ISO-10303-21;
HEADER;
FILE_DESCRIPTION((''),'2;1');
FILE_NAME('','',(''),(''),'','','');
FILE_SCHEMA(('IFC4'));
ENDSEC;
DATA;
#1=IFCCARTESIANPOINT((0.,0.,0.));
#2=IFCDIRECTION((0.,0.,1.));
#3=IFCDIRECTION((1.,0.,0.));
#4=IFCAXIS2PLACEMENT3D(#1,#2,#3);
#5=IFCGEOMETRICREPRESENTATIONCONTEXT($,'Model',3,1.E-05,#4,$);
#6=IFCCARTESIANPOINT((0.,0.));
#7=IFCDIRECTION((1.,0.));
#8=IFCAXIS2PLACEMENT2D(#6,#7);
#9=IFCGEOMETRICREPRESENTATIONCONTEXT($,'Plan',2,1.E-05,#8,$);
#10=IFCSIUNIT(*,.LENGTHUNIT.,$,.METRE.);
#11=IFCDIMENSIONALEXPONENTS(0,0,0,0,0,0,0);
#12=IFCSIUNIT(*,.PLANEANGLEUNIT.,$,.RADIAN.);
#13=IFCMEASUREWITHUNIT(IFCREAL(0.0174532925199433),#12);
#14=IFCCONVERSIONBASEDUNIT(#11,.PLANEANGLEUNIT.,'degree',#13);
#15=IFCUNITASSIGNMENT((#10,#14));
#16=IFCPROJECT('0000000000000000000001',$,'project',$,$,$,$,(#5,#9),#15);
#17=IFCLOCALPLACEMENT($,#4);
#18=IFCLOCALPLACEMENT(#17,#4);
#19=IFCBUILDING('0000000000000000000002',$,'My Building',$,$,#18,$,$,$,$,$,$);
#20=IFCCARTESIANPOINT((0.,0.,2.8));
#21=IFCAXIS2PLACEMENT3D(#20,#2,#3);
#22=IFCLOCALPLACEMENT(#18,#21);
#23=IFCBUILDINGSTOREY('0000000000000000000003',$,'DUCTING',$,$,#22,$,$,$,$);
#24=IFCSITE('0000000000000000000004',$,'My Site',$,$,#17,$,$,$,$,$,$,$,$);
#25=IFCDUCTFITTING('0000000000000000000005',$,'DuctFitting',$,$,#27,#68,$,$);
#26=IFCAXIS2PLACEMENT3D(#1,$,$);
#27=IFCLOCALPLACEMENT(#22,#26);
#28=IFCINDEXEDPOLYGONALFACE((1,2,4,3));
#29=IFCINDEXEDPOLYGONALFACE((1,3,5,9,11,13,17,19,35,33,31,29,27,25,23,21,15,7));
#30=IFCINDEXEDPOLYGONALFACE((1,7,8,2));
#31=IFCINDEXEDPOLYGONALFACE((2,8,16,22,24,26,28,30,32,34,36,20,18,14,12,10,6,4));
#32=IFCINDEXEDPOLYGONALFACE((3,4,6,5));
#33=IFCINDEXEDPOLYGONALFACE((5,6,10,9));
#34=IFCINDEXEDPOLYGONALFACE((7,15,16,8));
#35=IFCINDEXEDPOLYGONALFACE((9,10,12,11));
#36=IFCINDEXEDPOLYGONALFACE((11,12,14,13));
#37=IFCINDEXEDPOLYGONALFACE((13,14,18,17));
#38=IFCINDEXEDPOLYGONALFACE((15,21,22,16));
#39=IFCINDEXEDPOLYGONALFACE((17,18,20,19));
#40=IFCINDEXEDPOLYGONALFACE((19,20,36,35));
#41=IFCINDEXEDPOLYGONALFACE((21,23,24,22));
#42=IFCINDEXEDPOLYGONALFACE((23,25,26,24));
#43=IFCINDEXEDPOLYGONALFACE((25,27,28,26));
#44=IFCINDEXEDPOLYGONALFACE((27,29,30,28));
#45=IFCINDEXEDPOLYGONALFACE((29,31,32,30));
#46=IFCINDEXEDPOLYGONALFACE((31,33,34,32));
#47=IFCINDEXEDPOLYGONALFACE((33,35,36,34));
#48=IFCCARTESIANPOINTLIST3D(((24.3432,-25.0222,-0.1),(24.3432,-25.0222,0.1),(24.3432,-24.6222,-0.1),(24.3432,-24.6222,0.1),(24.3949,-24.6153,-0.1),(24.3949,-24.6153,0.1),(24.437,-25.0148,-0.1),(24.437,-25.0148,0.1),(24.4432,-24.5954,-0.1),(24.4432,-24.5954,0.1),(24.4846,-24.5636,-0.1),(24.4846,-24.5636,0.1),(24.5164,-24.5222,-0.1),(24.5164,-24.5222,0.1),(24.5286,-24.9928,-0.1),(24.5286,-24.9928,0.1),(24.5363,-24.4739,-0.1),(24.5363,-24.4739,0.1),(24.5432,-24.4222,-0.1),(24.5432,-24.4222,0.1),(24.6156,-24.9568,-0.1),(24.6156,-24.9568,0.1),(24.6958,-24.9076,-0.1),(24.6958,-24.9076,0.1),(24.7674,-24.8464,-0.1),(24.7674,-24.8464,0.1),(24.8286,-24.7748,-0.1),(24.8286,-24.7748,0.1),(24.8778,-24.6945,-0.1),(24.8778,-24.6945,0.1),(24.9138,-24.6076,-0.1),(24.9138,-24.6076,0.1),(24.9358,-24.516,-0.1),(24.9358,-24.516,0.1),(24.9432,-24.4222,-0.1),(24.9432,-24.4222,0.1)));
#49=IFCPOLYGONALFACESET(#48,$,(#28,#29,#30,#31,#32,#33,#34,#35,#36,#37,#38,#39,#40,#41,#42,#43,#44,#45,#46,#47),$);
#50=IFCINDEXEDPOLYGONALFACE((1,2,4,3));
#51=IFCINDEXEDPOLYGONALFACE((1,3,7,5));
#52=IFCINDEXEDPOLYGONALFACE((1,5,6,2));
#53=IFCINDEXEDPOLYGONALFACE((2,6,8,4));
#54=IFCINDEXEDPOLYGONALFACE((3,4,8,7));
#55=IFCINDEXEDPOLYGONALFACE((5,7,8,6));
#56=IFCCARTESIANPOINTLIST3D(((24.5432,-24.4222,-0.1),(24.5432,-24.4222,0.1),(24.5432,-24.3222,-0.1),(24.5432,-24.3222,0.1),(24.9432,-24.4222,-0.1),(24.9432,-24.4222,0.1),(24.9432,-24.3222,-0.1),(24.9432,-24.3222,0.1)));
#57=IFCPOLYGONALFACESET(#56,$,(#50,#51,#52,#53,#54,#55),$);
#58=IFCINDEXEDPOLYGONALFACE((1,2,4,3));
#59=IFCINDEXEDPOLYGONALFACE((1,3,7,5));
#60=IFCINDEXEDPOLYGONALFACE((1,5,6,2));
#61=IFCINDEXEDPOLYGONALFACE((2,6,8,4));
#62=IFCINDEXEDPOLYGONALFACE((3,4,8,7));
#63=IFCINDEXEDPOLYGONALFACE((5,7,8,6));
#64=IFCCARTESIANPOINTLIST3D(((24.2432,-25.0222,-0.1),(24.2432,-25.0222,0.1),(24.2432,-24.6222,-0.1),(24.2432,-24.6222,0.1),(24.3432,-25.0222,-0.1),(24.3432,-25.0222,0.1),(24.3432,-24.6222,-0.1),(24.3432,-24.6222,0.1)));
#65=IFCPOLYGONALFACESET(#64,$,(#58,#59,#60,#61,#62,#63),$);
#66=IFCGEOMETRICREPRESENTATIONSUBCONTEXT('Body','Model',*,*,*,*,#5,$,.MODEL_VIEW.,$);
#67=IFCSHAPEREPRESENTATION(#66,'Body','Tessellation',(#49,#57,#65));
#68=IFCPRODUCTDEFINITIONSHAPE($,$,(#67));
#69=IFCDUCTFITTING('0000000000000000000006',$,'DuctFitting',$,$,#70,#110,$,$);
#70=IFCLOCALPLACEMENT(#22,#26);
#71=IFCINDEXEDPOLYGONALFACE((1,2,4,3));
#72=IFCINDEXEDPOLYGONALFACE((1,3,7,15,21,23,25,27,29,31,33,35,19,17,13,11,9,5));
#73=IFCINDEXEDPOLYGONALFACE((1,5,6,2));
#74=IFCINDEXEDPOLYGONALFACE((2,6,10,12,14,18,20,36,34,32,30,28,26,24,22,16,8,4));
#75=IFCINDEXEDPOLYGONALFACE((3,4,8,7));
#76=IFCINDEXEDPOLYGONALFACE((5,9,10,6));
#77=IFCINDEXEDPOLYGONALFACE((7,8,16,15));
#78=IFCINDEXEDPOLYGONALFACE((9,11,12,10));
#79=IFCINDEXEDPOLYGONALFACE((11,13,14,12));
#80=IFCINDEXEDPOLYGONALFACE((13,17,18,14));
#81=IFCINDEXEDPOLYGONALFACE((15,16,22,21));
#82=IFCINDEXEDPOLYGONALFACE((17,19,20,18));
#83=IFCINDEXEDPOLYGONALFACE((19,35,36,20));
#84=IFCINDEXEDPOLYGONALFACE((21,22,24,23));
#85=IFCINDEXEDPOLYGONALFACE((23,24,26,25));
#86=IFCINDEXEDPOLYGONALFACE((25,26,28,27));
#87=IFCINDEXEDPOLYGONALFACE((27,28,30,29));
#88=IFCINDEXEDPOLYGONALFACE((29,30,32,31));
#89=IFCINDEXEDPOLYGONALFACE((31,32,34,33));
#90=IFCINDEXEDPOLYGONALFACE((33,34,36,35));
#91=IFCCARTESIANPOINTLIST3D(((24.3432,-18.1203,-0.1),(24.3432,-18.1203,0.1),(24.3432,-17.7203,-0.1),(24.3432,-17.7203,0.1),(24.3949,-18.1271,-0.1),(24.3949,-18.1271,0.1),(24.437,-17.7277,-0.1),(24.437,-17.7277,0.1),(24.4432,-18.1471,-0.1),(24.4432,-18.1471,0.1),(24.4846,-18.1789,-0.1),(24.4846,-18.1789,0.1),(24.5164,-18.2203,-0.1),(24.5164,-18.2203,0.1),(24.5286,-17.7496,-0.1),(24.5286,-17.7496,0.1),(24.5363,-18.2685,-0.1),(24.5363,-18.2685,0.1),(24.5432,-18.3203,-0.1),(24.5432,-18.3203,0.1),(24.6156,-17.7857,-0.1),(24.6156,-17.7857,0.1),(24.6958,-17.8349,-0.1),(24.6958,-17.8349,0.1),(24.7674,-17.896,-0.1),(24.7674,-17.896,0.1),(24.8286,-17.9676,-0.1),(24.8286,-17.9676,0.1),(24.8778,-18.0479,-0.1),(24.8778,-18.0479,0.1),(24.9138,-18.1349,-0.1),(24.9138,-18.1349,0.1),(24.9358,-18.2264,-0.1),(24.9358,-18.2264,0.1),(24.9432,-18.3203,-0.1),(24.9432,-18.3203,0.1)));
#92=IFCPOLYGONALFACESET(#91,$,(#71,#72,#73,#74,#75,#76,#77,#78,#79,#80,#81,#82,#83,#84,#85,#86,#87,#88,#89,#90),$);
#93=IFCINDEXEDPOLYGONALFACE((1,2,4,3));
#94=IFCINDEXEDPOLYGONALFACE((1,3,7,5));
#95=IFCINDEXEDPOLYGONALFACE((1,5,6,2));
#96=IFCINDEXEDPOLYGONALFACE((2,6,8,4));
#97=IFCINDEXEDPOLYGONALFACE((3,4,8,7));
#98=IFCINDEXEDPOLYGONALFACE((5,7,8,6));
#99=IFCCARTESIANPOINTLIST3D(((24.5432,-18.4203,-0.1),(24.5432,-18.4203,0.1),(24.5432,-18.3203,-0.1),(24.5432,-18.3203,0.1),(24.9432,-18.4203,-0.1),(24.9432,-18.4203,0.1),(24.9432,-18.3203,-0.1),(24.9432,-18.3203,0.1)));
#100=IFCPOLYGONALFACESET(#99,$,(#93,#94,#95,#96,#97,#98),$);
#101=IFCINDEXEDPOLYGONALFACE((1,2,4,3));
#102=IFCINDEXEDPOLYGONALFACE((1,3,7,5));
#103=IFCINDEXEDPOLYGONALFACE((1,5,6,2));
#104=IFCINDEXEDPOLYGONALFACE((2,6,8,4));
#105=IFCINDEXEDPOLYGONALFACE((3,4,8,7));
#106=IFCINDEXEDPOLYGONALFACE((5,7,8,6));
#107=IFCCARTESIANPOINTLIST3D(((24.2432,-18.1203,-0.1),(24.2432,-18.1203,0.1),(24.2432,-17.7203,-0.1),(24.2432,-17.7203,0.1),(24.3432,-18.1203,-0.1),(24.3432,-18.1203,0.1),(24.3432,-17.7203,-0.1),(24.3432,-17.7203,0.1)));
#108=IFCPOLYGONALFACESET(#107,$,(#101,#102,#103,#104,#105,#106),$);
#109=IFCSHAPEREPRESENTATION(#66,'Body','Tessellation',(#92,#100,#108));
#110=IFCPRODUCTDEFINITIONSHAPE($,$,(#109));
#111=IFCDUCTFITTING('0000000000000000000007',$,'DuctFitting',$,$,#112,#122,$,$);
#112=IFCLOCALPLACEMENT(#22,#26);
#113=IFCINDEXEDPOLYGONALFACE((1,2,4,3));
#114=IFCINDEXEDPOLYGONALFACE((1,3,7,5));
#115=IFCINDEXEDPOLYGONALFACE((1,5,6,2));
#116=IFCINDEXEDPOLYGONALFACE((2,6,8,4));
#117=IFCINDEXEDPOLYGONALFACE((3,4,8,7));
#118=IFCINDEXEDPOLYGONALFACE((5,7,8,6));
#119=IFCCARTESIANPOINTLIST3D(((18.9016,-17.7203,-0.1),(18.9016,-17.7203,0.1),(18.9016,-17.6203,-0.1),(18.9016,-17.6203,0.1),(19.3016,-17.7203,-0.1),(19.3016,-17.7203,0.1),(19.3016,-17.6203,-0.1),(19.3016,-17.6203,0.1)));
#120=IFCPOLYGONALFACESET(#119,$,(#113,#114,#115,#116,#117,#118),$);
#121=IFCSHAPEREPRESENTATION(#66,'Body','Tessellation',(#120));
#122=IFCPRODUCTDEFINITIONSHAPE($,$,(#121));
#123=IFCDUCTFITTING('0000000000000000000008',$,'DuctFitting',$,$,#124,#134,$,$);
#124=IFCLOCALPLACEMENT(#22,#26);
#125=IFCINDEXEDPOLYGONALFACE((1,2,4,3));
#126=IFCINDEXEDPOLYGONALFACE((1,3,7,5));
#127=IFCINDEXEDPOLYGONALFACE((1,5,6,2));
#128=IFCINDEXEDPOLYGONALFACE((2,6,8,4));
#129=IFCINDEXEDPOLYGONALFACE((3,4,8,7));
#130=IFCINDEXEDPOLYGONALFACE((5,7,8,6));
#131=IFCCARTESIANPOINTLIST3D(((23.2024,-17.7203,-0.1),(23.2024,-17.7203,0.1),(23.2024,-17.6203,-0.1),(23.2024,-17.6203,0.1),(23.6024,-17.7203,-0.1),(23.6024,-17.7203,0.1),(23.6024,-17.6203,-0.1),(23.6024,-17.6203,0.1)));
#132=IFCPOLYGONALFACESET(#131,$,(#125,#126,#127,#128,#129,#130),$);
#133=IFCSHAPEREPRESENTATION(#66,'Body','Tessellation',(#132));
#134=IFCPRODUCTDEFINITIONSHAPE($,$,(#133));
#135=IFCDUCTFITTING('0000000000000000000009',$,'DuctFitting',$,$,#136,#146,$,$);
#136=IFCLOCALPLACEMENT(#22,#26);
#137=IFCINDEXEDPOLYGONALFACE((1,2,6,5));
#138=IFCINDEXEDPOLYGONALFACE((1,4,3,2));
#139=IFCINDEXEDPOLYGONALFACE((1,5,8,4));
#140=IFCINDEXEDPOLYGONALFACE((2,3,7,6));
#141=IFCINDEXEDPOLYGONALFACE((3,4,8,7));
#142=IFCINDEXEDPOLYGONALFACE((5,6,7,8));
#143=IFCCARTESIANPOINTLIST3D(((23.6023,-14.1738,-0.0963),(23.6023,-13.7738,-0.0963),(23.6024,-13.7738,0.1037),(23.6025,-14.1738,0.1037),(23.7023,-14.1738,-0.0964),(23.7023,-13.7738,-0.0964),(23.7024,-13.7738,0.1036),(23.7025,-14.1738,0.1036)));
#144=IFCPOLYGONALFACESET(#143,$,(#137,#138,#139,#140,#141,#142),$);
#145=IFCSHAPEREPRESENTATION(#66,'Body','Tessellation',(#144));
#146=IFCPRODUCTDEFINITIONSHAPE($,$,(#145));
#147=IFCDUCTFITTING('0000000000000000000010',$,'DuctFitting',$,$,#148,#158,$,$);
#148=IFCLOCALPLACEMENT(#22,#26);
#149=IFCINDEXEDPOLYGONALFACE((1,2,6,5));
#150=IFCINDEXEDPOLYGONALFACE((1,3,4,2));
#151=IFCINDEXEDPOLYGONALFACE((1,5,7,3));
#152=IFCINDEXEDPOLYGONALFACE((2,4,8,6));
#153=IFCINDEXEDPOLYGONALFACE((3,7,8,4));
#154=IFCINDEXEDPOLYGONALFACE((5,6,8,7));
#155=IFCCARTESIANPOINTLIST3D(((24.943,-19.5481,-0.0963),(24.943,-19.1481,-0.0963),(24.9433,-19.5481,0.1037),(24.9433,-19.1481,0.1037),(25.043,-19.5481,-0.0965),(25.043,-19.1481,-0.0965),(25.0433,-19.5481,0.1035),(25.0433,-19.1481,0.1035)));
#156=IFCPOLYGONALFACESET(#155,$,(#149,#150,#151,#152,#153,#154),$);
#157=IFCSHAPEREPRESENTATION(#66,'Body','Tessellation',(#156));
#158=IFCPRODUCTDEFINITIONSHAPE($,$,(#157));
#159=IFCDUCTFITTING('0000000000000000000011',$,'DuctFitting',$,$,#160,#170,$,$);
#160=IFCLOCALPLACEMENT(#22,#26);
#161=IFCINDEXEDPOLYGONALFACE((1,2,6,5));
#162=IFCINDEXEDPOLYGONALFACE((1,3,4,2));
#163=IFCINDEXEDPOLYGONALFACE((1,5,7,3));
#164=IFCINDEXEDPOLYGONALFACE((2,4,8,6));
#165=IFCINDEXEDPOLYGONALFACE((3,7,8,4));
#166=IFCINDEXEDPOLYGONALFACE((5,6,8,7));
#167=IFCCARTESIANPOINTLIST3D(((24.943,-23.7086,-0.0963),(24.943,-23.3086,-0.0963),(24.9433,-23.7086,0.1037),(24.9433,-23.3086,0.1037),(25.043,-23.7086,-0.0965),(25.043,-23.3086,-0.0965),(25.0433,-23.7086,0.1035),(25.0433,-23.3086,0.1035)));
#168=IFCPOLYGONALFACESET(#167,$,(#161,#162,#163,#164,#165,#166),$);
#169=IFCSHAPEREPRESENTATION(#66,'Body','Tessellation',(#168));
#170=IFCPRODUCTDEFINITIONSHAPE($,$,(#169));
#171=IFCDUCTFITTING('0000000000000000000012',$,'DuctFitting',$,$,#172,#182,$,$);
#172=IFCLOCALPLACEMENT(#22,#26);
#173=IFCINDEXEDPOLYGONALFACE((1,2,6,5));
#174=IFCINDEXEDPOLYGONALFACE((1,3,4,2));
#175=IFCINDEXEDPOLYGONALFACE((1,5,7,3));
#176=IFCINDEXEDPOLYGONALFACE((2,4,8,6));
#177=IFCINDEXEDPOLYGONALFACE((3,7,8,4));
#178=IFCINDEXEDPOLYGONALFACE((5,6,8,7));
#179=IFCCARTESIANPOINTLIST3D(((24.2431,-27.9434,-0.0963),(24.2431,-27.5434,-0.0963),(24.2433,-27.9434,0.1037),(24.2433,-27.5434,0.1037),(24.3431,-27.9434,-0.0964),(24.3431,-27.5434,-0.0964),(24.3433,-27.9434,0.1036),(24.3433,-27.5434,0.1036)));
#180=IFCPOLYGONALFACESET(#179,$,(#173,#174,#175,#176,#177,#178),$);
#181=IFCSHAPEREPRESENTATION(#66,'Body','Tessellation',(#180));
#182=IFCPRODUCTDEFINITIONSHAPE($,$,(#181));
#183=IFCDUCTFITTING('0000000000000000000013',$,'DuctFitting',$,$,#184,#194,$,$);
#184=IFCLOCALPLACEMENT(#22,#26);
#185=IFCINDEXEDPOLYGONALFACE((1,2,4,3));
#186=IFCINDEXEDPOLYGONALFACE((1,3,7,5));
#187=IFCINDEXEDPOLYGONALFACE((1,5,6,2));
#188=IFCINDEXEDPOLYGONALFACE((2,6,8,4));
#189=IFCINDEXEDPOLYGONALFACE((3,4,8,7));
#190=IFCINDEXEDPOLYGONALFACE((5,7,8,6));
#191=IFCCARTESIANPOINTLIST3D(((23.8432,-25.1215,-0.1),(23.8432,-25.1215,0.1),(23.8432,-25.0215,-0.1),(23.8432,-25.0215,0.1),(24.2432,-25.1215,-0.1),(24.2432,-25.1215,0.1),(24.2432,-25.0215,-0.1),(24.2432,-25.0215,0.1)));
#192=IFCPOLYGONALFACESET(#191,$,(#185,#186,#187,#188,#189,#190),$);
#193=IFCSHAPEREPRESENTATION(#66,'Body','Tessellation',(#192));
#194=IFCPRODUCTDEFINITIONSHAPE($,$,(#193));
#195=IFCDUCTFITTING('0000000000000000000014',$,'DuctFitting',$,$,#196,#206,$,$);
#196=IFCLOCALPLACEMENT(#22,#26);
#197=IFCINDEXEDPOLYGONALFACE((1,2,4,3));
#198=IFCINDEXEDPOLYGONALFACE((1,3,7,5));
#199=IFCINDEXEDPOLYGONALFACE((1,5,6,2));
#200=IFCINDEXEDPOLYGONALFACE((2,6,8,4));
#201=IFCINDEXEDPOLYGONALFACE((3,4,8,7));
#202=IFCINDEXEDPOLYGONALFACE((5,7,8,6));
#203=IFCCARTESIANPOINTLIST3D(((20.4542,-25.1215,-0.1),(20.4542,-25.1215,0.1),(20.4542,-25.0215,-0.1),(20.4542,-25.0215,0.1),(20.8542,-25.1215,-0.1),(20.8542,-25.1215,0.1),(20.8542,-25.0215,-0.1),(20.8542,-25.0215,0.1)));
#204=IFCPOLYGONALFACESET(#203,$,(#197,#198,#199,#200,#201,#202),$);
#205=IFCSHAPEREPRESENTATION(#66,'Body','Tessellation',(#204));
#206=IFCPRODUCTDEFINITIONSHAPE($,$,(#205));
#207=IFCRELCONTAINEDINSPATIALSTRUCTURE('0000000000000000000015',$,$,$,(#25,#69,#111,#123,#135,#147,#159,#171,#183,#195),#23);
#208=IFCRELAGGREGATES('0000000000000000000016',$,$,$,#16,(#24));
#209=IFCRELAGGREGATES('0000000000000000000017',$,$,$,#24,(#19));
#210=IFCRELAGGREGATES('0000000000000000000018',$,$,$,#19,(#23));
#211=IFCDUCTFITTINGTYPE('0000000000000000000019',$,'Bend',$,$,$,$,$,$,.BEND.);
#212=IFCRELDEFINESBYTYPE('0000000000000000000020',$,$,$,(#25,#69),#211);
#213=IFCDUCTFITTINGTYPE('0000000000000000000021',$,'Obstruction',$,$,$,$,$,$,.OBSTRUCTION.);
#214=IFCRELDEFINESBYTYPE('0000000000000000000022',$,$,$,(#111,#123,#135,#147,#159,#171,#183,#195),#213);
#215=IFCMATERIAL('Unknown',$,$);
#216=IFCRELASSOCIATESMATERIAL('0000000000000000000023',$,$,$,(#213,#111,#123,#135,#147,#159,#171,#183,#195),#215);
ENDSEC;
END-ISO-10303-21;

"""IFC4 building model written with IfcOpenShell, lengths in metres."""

from ifc_helpers import new_model, entity, si_unit, converted_unit, frame, origin_with_axes, origin_2d_with_axis, place, context, subcontext, project, spatial, line, arc, indexed_curve, rectangle, outline, extrude, source, transform, mapped, material, material_profile, profile_set, profile_usage, type_object, type_shapes, element, save


model = new_model("IFC4")

# Units and contexts
model_context = context("Model", 3, precision=1e-05, world=origin_with_axes())
plan_context = context("Plan", 2, precision=1e-05, world=origin_2d_with_axis())
body_context = subcontext(model_context, "Body", "Model", "MODEL_VIEW")
ifc_project = project(units=[si_unit("LENGTHUNIT", "METRE"), converted_unit("PLANEANGLEUNIT", "degree", entity("IfcReal", 0.0174532925199433), si_unit("PLANEANGLEUNIT", "RADIAN"), dimensions=[0, 0, 0, 0, 0, 0, 0])], contexts=[model_context, plan_context])

# Site, building, storey
site_placement = place(None, origin_with_axes())
site = spatial("IfcSite", under=ifc_project, at=site_placement, Name="My Site")
building_placement = place(site_placement, origin_with_axes())
building = spatial("IfcBuilding", under=site, at=building_placement, Name="My Building")
storey_placement = place(building_placement, frame((0.0, 0.0, 2.8), z_axis=(0.0, 0.0, 1.0), x_axis=(1.0, 0.0, 0.0)))
storey = spatial("IfcBuildingStorey", under=building, at=storey_placement, Name="DUCTING")

# Shared definitions
ifc_material = material(Name="Unknown")

# Duct fittings
duct_fitting_type_1 = type_object("IfcDuctFittingType", Name="Bend", PredefinedType="BEND")
shared_shape = source(origin_with_axes(), body_context, "Body", "SweptSolid", [
    extrude(outline(indexed_curve([(-0.2, 0.0), (-0.2586, 0.1414), (-0.4, 0.2), (-0.4, 0.6), (0.0243, 0.4243), (0.2, 0.0)], segments=[arc(1, 2, 3), line(3, 4), arc(4, 5, 6), line(6, 1)])), frame((0.0, -0.1, 0.1), z_axis=(0.0, -1.0, 0.0), x_axis=(1.0, 0.0, 0.0)), (0.0, 0.0, -1.0), 0.2),
    extrude(rectangle(XDim=0.4, YDim=0.2), origin_with_axes(), (0.0, 0.0, 1.0), 0.1),
    extrude(rectangle(XDim=0.4, YDim=0.2), frame((-0.4, 0.0, 0.5), z_axis=(-1.0, 0.0, 0.0), x_axis=(0.0, 0.0, -1.0)), (0.0, 0.0, 1.0), 0.1),
])
type_shapes(duct_fitting_type_1, [shared_shape])
for number, where, z_axis, x_axis, name in (
    (1, (24.7432, -24.3222, 0.0), (0.0, -1.0, 0.0), (1.0, 0.0, 0.0), "DuctFitting"),
    (2, (24.7432, -18.4203, 0.0), (0.0, 1.0, 0.0), (1.0, 0.0, 0.0), "DuctFitting"),
):
    element("IfcDuctFitting", number, at=place(storey_placement, frame(where, z_axis=z_axis, x_axis=x_axis)), inside=storey, type_object=duct_fitting_type_1, Name=name, context=body_context, shape_type="MappedRepresentation", body=[
        mapped(shared_shape, transform((0.0, 0.0, 0.0), x_axis=(1.0, 0.0, 0.0), y_axis=(0.0, 1.0, 0.0), z_axis=(0.0, 0.0, 1.0), scale=1.0)),
    ])
ifc_material_profile_1 = material_profile(ifc_material, rectangle(XDim=0.4, YDim=0.2))
ifc_profile_set_1 = profile_set([ifc_material_profile_1])
ifc_profile_usage_1 = profile_usage(ifc_profile_set_1, cardinal=5)
duct_fitting_type_2 = type_object("IfcDuctFittingType", Name="Obstruction", PredefinedType="OBSTRUCTION", material=ifc_profile_set_1)
duct_fitting_1_placement = place(storey_placement, frame((19.1016, -17.6203, 0.0), z_axis=(0.0, -1.0, 0.0), x_axis=(1.0, 0.0, 0.0)))
element("IfcDuctFitting", 3, at=duct_fitting_1_placement, inside=storey, type_object=duct_fitting_type_2, material=ifc_profile_usage_1, Name="DuctFitting", context=body_context, shape_type="SweptSolid", body=[
    extrude(rectangle(XDim=0.4, YDim=0.2), origin_with_axes(), (0.0, 0.0, 1.0), 0.1),
])
ifc_profile_usage_2 = profile_usage(ifc_profile_set_1, cardinal=5)
duct_fitting_2_placement = place(storey_placement, frame((23.4024, -17.6203, 0.0), z_axis=(0.0, -1.0, 0.0), x_axis=(1.0, 0.0, 0.0)))
element("IfcDuctFitting", 4, at=duct_fitting_2_placement, inside=storey, type_object=duct_fitting_type_2, material=ifc_profile_usage_2, Name="DuctFitting", context=body_context, shape_type="SweptSolid", body=[
    extrude(rectangle(XDim=0.4, YDim=0.2), origin_with_axes(), (0.0, 0.0, 1.0), 0.1),
])
ifc_profile_usage_3 = profile_usage(ifc_profile_set_1, cardinal=5)
duct_fitting_3_placement = place(storey_placement, frame((23.7024, -13.9738, 0.0036), z_axis=(-1.0, -0.000006, 0.00093), x_axis=(0.000006, -1.0, 0.0)))
element("IfcDuctFitting", 5, at=duct_fitting_3_placement, inside=storey, type_object=duct_fitting_type_2, material=ifc_profile_usage_3, Name="DuctFitting", context=body_context, shape_type="SweptSolid", body=[
    extrude(rectangle(XDim=0.4, YDim=0.2), origin_with_axes(), (0.0, 0.0, 1.0), 0.1),
])
ifc_profile_usage_4 = profile_usage(ifc_profile_set_1, cardinal=5)
duct_fitting_4_placement = place(storey_placement, frame((25.0432, -19.3481, 0.0035), z_axis=(-0.999999, -0.000009, 0.001405), x_axis=(0.000009, -1.0, 0.0)))
element("IfcDuctFitting", 6, at=duct_fitting_4_placement, inside=storey, type_object=duct_fitting_type_2, material=ifc_profile_usage_4, Name="DuctFitting", context=body_context, shape_type="SweptSolid", body=[
    extrude(rectangle(XDim=0.4, YDim=0.2), origin_with_axes(), (0.0, 0.0, 1.0), 0.1),
])
ifc_profile_usage_5 = profile_usage(ifc_profile_set_1, cardinal=5)
duct_fitting_5_placement = place(storey_placement, frame((25.0432, -23.5086, 0.0035), z_axis=(-0.999999, -0.000009, 0.001405), x_axis=(0.000009, -1.0, 0.0)))
element("IfcDuctFitting", 7, at=duct_fitting_5_placement, inside=storey, type_object=duct_fitting_type_2, material=ifc_profile_usage_5, Name="DuctFitting", context=body_context, shape_type="SweptSolid", body=[
    extrude(rectangle(XDim=0.4, YDim=0.2), origin_with_axes(), (0.0, 0.0, 1.0), 0.1),
])
ifc_profile_usage_6 = profile_usage(ifc_profile_set_1, cardinal=5)
duct_fitting_6_placement = place(storey_placement, frame((24.3432, -27.7434, 0.0036), z_axis=(-0.999999, -0.000008, 0.001109), x_axis=(0.000008, -1.0, 0.0)))
element("IfcDuctFitting", 8, at=duct_fitting_6_placement, inside=storey, type_object=duct_fitting_type_2, material=ifc_profile_usage_6, Name="DuctFitting", context=body_context, shape_type="SweptSolid", body=[
    extrude(rectangle(XDim=0.4, YDim=0.2), origin_with_axes(), (0.0, 0.0, 1.0), 0.1),
])
ifc_profile_usage_7 = profile_usage(ifc_profile_set_1, cardinal=5)
duct_fitting_7_placement = place(storey_placement, frame((24.0432, -25.1215, 0.0), z_axis=(0.0, 1.0, 0.0), x_axis=(-1.0, 0.0, 0.0)))
element("IfcDuctFitting", 9, at=duct_fitting_7_placement, inside=storey, type_object=duct_fitting_type_2, material=ifc_profile_usage_7, Name="DuctFitting", context=body_context, shape_type="SweptSolid", body=[
    extrude(rectangle(XDim=0.4, YDim=0.2), origin_with_axes(), (0.0, 0.0, 1.0), 0.1),
])
ifc_profile_usage_8 = profile_usage(ifc_profile_set_1, cardinal=5)
duct_fitting_8_placement = place(storey_placement, frame((20.6542, -25.1215, 0.0), z_axis=(0.0, 1.0, 0.0), x_axis=(-1.0, 0.0, 0.0)))
element("IfcDuctFitting", 10, at=duct_fitting_8_placement, inside=storey, type_object=duct_fitting_type_2, material=ifc_profile_usage_8, Name="DuctFitting", context=body_context, shape_type="SweptSolid", body=[
    extrude(rectangle(XDim=0.4, YDim=0.2), origin_with_axes(), (0.0, 0.0, 1.0), 0.1),
])

save(model, "model.ifc")
